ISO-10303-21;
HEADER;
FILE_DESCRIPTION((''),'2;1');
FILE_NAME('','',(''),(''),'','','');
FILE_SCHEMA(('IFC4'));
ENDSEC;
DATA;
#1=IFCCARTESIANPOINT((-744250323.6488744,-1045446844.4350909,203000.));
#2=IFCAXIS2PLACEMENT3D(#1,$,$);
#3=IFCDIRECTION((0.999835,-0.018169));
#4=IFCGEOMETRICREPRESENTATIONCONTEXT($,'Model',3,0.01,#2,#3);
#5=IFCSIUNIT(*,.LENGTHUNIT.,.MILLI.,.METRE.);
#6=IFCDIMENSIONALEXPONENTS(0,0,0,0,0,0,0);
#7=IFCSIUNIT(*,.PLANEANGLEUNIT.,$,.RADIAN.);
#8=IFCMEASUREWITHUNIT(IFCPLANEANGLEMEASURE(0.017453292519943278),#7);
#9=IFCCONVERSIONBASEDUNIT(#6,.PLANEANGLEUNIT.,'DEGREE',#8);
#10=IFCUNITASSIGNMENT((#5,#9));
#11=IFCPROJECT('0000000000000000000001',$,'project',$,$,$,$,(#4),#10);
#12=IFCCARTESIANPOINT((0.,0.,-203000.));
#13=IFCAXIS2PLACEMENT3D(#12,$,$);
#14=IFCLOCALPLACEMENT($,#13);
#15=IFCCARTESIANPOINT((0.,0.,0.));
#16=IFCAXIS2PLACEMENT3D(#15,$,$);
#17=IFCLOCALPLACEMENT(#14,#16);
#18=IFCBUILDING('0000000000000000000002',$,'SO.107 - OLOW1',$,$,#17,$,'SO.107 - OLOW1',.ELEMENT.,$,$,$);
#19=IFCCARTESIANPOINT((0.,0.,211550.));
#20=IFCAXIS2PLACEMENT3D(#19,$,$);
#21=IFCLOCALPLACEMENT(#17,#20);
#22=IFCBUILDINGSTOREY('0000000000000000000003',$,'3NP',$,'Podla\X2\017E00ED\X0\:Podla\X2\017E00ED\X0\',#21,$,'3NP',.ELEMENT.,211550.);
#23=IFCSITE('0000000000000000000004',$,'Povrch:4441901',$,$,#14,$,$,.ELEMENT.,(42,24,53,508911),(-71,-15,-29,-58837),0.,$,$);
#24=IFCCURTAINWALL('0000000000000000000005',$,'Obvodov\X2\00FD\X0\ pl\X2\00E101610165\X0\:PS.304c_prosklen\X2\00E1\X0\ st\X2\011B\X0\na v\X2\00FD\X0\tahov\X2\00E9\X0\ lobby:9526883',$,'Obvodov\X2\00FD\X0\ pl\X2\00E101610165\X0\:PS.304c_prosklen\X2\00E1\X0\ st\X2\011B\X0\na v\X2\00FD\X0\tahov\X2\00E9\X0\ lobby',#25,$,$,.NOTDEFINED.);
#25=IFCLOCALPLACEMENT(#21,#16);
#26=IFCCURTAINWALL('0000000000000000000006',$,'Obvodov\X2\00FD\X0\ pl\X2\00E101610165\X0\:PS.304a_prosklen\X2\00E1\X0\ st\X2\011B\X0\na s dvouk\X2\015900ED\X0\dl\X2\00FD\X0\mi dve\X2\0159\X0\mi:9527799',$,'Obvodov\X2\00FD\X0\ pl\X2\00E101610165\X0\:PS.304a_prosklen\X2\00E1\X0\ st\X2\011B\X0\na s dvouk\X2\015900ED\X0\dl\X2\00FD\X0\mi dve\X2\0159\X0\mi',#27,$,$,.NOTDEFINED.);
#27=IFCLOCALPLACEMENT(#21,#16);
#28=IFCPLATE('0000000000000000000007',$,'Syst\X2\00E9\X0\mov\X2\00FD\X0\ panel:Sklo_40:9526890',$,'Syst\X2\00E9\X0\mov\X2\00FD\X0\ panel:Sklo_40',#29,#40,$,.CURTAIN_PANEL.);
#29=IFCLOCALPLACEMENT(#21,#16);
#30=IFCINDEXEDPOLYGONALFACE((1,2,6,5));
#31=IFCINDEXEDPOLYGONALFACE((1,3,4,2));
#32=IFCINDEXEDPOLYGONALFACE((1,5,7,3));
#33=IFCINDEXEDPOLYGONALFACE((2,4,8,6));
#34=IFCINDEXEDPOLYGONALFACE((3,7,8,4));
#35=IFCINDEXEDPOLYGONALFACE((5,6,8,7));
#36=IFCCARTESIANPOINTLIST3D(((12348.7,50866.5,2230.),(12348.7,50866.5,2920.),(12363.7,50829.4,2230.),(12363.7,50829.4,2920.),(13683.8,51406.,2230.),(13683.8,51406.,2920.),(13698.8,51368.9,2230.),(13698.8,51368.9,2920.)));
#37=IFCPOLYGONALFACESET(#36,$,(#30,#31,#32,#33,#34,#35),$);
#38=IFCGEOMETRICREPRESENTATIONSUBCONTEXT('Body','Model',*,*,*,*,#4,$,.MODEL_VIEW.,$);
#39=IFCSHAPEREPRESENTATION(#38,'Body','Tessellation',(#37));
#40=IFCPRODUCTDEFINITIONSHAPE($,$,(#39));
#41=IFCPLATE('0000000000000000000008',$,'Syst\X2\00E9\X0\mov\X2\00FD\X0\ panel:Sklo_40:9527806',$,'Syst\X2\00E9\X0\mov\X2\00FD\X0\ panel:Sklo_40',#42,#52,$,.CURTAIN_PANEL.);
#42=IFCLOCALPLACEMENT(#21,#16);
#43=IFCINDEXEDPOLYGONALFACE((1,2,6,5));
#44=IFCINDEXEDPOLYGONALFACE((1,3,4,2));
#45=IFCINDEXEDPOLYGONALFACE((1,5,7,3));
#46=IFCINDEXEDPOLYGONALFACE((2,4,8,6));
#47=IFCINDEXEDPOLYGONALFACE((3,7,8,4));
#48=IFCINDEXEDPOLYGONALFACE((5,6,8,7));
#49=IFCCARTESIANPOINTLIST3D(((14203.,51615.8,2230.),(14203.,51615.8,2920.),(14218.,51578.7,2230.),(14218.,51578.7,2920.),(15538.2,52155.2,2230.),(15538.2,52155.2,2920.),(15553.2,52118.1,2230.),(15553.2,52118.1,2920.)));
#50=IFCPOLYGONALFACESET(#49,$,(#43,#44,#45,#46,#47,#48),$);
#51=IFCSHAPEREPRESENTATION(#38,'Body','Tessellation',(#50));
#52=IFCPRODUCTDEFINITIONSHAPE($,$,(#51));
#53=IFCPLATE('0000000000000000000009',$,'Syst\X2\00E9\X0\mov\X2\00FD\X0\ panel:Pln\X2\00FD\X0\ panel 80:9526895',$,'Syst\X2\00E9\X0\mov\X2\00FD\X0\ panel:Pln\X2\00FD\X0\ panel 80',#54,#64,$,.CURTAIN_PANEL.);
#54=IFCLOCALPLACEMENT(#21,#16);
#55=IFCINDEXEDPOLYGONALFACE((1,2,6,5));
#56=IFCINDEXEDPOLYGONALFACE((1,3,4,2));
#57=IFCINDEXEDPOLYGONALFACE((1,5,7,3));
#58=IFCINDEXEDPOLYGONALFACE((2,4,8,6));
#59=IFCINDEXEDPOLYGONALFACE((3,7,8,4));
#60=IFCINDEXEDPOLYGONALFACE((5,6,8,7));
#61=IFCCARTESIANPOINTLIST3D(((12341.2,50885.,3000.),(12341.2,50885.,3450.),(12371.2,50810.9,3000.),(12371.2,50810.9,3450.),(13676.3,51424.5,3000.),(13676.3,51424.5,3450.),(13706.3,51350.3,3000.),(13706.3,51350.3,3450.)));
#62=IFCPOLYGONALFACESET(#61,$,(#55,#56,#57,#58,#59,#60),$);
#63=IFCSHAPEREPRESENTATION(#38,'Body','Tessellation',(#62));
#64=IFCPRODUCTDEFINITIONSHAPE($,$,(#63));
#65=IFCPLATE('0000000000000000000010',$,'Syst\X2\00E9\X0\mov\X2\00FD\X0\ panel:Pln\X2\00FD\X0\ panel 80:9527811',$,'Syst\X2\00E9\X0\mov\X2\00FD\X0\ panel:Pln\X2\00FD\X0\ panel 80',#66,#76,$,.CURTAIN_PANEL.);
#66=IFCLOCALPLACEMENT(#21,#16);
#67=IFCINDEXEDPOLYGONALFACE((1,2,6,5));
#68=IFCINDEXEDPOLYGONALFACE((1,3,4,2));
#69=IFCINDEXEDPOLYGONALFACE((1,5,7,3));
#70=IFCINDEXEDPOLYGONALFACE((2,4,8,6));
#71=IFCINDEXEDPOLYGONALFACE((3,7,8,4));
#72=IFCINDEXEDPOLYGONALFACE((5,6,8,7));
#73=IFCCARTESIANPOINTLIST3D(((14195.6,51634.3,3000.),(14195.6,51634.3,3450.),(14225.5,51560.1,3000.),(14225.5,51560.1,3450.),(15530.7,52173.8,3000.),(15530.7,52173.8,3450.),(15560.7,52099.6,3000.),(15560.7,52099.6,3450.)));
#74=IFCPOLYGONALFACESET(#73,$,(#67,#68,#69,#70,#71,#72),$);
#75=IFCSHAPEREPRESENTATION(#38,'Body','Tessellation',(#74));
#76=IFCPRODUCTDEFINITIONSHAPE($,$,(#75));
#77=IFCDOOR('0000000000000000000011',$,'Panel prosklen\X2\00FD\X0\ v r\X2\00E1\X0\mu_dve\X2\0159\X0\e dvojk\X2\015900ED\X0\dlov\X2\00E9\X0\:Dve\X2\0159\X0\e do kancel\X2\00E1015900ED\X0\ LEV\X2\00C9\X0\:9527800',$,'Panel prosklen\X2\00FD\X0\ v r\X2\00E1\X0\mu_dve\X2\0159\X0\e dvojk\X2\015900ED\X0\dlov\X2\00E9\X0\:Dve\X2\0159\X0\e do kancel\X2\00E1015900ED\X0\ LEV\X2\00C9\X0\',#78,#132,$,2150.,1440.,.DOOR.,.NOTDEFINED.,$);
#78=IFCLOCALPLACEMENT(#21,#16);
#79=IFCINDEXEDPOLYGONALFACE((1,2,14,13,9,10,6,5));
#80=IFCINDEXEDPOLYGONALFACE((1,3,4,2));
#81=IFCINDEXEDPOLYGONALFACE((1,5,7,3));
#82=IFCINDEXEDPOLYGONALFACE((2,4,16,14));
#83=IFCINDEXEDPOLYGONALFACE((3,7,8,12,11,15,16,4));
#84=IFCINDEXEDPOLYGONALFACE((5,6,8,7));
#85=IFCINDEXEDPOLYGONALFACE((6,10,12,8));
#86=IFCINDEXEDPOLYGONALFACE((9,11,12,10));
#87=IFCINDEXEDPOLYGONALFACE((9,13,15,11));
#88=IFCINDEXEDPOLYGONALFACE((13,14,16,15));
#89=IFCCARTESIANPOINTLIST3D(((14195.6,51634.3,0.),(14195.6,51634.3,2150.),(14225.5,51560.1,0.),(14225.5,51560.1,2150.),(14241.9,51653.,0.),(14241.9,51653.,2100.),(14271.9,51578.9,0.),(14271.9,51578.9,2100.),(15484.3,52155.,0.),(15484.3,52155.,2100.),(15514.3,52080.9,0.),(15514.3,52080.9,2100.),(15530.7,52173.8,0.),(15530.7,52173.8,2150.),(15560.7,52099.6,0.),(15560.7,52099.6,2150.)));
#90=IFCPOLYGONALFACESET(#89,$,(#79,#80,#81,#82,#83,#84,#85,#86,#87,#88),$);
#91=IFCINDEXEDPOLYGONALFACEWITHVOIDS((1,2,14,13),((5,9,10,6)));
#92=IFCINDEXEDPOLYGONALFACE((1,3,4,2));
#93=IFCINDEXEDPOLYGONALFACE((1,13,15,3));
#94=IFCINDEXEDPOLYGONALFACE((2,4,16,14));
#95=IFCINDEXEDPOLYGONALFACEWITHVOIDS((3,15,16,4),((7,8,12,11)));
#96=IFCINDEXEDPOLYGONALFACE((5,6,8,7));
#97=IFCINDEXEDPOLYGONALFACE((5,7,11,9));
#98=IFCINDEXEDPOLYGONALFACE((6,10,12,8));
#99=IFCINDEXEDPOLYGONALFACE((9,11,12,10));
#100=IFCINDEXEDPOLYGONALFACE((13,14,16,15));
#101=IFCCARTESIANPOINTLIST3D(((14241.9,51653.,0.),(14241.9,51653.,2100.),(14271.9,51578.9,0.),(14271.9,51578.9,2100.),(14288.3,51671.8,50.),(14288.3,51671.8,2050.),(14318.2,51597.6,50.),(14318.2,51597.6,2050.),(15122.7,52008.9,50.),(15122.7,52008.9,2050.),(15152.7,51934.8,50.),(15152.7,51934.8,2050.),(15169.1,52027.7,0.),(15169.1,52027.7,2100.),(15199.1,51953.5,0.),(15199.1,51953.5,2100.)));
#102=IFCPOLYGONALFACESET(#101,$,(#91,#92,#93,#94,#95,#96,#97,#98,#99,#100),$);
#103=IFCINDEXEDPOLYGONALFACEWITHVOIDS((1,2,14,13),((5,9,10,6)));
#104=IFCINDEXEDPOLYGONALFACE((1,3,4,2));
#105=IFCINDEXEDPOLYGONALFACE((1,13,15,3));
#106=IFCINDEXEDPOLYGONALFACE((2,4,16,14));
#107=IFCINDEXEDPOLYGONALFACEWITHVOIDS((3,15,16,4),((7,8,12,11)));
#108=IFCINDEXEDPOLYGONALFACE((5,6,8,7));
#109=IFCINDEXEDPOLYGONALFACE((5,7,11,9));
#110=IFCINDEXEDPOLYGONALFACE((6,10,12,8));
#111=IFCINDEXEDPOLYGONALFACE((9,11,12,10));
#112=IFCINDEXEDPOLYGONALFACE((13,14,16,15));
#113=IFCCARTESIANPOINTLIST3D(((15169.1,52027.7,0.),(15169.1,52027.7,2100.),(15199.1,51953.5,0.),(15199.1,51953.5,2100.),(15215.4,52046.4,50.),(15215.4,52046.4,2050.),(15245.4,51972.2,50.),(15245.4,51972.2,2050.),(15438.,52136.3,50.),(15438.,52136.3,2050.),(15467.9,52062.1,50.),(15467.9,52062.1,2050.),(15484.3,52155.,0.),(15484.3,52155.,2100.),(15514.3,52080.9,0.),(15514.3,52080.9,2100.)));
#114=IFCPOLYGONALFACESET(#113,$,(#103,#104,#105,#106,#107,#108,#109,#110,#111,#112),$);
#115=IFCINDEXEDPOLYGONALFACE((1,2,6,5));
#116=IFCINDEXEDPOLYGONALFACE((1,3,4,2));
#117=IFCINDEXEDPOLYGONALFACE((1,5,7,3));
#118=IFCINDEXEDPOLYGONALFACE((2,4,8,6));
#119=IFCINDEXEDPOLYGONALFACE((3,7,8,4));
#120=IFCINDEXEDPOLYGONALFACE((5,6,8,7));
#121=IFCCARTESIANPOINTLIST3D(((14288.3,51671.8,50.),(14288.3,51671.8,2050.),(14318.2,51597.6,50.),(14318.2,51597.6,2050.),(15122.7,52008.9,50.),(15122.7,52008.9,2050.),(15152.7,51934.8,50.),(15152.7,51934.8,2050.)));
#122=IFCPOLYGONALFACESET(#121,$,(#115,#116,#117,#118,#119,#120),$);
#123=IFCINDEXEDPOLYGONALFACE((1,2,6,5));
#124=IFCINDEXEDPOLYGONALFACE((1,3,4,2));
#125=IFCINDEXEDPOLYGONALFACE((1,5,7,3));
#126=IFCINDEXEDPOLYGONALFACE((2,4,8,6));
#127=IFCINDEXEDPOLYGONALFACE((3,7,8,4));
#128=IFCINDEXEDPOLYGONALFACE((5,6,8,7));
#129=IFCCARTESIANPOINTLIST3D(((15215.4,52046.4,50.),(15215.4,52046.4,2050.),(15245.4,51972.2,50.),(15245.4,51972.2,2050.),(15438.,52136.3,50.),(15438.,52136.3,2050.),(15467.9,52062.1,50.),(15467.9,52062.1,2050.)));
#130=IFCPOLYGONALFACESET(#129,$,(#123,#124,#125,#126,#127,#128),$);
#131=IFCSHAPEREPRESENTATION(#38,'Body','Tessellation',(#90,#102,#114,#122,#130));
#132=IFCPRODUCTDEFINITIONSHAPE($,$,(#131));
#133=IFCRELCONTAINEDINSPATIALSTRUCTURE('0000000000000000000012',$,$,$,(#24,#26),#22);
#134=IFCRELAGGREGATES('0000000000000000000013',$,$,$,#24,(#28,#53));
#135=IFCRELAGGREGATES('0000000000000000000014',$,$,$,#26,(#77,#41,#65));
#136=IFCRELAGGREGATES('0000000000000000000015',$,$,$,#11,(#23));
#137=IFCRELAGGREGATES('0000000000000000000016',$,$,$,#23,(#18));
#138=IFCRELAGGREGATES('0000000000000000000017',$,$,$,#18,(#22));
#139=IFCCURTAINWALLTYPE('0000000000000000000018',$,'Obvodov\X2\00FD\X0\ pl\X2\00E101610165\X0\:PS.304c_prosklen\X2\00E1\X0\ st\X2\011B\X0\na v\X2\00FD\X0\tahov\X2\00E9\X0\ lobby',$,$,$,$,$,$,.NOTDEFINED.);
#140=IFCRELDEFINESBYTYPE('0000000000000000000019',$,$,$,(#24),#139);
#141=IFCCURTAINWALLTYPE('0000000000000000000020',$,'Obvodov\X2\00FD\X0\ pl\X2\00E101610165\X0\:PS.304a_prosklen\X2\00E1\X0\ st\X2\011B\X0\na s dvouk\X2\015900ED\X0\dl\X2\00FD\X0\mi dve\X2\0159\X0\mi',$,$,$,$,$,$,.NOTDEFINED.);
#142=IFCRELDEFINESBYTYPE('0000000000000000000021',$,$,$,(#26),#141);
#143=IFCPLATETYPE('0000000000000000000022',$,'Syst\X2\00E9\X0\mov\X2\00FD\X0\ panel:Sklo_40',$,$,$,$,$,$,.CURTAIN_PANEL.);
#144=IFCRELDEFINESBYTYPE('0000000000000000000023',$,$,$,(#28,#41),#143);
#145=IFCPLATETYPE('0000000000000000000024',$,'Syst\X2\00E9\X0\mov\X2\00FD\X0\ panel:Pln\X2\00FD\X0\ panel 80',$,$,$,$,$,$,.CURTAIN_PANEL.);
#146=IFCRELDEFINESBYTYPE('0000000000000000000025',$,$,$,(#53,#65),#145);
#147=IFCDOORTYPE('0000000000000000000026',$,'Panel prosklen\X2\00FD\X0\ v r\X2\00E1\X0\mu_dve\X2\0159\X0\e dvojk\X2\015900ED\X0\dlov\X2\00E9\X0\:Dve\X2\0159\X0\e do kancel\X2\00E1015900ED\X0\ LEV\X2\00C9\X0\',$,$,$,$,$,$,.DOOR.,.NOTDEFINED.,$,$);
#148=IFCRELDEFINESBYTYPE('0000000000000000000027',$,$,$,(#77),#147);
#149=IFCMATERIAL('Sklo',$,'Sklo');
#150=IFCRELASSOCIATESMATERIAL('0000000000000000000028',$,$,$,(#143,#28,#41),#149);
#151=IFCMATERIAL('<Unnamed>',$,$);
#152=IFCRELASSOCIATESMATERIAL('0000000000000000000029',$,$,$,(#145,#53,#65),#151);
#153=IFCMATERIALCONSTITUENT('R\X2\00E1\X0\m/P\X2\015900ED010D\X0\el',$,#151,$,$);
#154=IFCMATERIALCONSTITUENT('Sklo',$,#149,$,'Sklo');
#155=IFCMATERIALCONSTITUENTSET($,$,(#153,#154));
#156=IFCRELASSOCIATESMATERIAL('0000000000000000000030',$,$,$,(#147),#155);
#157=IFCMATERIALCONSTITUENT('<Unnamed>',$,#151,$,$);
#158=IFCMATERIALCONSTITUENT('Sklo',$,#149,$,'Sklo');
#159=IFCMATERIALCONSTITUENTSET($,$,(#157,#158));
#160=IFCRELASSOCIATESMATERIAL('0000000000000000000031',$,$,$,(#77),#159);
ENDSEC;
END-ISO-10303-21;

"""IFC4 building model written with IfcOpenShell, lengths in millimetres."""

from ifc_helpers import new_model, entity, si_unit, converted_unit, direction, frame, origin, place, context, subcontext, project, spatial, indexed_curve, outline, extrude, source, transform, mapped, material, constituent, constituent_set, type_object, type_shapes, element, aggregate, save


model = new_model("IFC4")

# Units and contexts
model_context = context("Model", 3, precision=0.01, world=frame((-744250323.6488744, -1045446844.4350909, 203000.0)), true_north=direction((0.999835, -0.018169)))
body_context = subcontext(model_context, "Body", "Model", "MODEL_VIEW")
ifc_project = project(units=[si_unit("LENGTHUNIT", "METRE", prefix="MILLI"), converted_unit("PLANEANGLEUNIT", "DEGREE", entity("IfcPlaneAngleMeasure", 0.017453292519943278), si_unit("PLANEANGLEUNIT", "RADIAN"), dimensions=[0, 0, 0, 0, 0, 0, 0])], contexts=[model_context])

# Site, building, storey
site_placement = place(None, frame((0.0, 0.0, -203000.0)))
site = spatial("IfcSite", under=ifc_project, at=site_placement, Name="Povrch:4441901", CompositionType="ELEMENT", RefLatitude=(42, 24, 53, 508911), RefLongitude=(-71, -15, -29, -58837), RefElevation=0.0)
building_placement = place(site_placement, origin())
building = spatial("IfcBuilding", under=site, at=building_placement, Name="SO.107 - OLOW1", LongName="SO.107 - OLOW1", CompositionType="ELEMENT")
storey_placement = place(building_placement, frame((0.0, 0.0, 211550.0)))
storey = spatial("IfcBuildingStorey", under=building, at=storey_placement, Name="3NP", ObjectType="Podlaží:Podlaží", LongName="3NP", CompositionType="ELEMENT", Elevation=211550.0)

# Curtain walls
curtain_wall_type_1 = type_object("IfcCurtainWallType", Name="Obvodový plášť:PS.304c_prosklená stěna výtahové lobby", PredefinedType="NOTDEFINED")
curtain_wall_1_placement = place(storey_placement, frame((0.0, 0.0, -211550.0)))
curtain_wall_1 = element("IfcCurtainWall", 1, at=curtain_wall_1_placement, inside=storey, type_object=curtain_wall_type_1, Name="Obvodový plášť:PS.304c_prosklená stěna výtahové lobby:9526883", ObjectType="Obvodový plášť:PS.304c_prosklená stěna výtahové lobby", PredefinedType="NOTDEFINED")
ifc_material_1 = material(Name="<Unnamed>")
curtain_wall_type_2 = type_object("IfcCurtainWallType", Name="Obvodový plášť:PS.304a_prosklená stěna s dvoukřídlými dveřmi", PredefinedType="NOTDEFINED")
curtain_wall_2_placement = place(storey_placement, frame((0.0, 0.0, -211550.0)))
curtain_wall_2 = element("IfcCurtainWall", 2, at=curtain_wall_2_placement, inside=storey, type_object=curtain_wall_type_2, Name="Obvodový plášť:PS.304a_prosklená stěna s dvoukřídlými dveřmi:9527799", ObjectType="Obvodový plášť:PS.304a_prosklená stěna s dvoukřídlými dveřmi", PredefinedType="NOTDEFINED")

# Plates
ifc_material_2 = material(Name="Sklo", Category="Sklo")
plate_type_1 = type_object("IfcPlateType", Name="Systémový panel:Sklo_40", PredefinedType="CURTAIN_PANEL", material=ifc_material_2)
shared_shape_1 = source(origin(), body_context, "Body", "SweptSolid", [
    extrude(outline(indexed_curve([(-20.0, -720.0), (20.0, -720.0), (20.0, 720.0), (-20.0, 720.0), (-20.0, -720.0)], self_intersect=False)), frame((0.0, 0.0, 0.0), z_axis=(0.0, 0.0, 1.0), x_axis=(0.0, 1.0, 0.0)), (0.0, 0.0, 1.0), 690.0),
])
type_shapes(plate_type_1, [shared_shape_1])
plate_1_placement = place(curtain_wall_1_placement, frame((13023.8, 51117.7, 213780.0), z_axis=(0.0, 0.0, 1.0), x_axis=(0.927176, 0.374626, 0.0)))
plate_1 = element("IfcPlate", 3, at=plate_1_placement, type_object=plate_type_1, material=ifc_material_2, Name="Systémový panel:Sklo_40:9526890", ObjectType="Systémový panel:Sklo_40", PredefinedType="CURTAIN_PANEL", context=body_context, shape_type="MappedRepresentation", body=[
    mapped(shared_shape_1, transform((0.0, 0.0, 0.0), scale=1.0)),
])
plate_2_placement = place(curtain_wall_2_placement, frame((14878.1, 51866.9, 213780.0), z_axis=(0.0, 0.0, 1.0), x_axis=(-0.927176, -0.374626, 0.0)))
plate_2 = element("IfcPlate", 4, at=plate_2_placement, type_object=plate_type_1, material=ifc_material_2, Name="Systémový panel:Sklo_40:9527806", ObjectType="Systémový panel:Sklo_40", PredefinedType="CURTAIN_PANEL", context=body_context, shape_type="MappedRepresentation", body=[
    mapped(shared_shape_1, transform((0.0, 0.0, 0.0), scale=1.0)),
])
plate_type_2 = type_object("IfcPlateType", Name="Systémový panel:Plný panel 80", PredefinedType="CURTAIN_PANEL", material=ifc_material_1)
shared_shape_2 = source(origin(), body_context, "Body", "SweptSolid", [
    extrude(outline(indexed_curve([(-40.0, -720.0), (40.0, -720.0), (40.0, 720.0), (-40.0, 720.0), (-40.0, -720.0)], self_intersect=False)), frame((0.0, 0.0, 0.0), z_axis=(0.0, 0.0, 1.0), x_axis=(0.0, 1.0, 0.0)), (0.0, 0.0, 1.0), 450.0),
])
type_shapes(plate_type_2, [shared_shape_2])
plate_3_placement = place(curtain_wall_1_placement, frame((13023.8, 51117.7, 214550.0), z_axis=(0.0, 0.0, 1.0), x_axis=(0.927176, 0.374626, 0.0)))
plate_3 = element("IfcPlate", 5, at=plate_3_placement, type_object=plate_type_2, material=ifc_material_1, Name="Systémový panel:Plný panel 80:9526895", ObjectType="Systémový panel:Plný panel 80", PredefinedType="CURTAIN_PANEL", context=body_context, shape_type="MappedRepresentation", body=[
    mapped(shared_shape_2, transform((0.0, 0.0, 0.0), scale=1.0)),
])
aggregate(curtain_wall_1, [plate_1, plate_3])
plate_4_placement = place(curtain_wall_2_placement, frame((14878.1, 51866.9, 214550.0), z_axis=(0.0, 0.0, 1.0), x_axis=(-0.927176, -0.374626, 0.0)))
plate_4 = element("IfcPlate", 6, at=plate_4_placement, type_object=plate_type_2, material=ifc_material_1, Name="Systémový panel:Plný panel 80:9527811", ObjectType="Systémový panel:Plný panel 80", PredefinedType="CURTAIN_PANEL", context=body_context, shape_type="MappedRepresentation", body=[
    mapped(shared_shape_2, transform((0.0, 0.0, 0.0), scale=1.0)),
])

# Door
ifc_constituent_1 = constituent(ifc_material_1, Name="<Unnamed>")
ifc_constituent_2 = constituent(ifc_material_2, Name="Sklo", Category="Sklo")
ifc_constituent_set_1 = constituent_set(constituents=[ifc_constituent_1, ifc_constituent_2])
ifc_constituent_3 = constituent(ifc_material_1, Name="Rám/Příčel")
ifc_constituent_4 = constituent(ifc_material_2, Name="Sklo", Category="Sklo")
ifc_constituent_set_2 = constituent_set(constituents=[ifc_constituent_3, ifc_constituent_4])
door_type = type_object("IfcDoorType", Name="Panel prosklený v rámu_dveře dvojkřídlové:Dveře do kanceláří LEVÉ", OperationType="NOTDEFINED", PredefinedType="DOOR", material=ifc_constituent_set_2)
shared_shape_3 = source(origin(), body_context, "Body", "SweptSolid", [
    extrude(outline(indexed_curve([(-720.0, -1087.5), (720.0, -1087.5), (720.0, 1062.5), (670.0, 1062.5), (670.0, -1037.5), (-670.0, -1037.5), (-670.0, 1062.5), (-720.0, 1062.5), (-720.0, -1087.5)], self_intersect=False)), frame((0.0, 40.0, 1062.5), z_axis=(0.0, -1.0, 0.0), x_axis=(-1.0, 0.0, 0.0)), (0.0, 0.0, 1.0), 80.0),
    extrude(outline(indexed_curve([(-1050.0, -500.0), (1050.0, -500.0), (1050.0, 500.0), (-1050.0, 500.0), (-1050.0, -500.0)], self_intersect=False), holes=[indexed_curve([(-1000.0, -450.0), (-1000.0, 450.0), (1000.0, 450.0), (1000.0, -450.0), (-1000.0, -450.0)], self_intersect=False)]), frame((-170.0, 40.0, 1050.0), z_axis=(0.0, -1.0, 0.0), x_axis=(0.0, 0.0, -1.0)), (0.0, 0.0, 1.0), 80.0),
    extrude(outline(indexed_curve([(-1050.0, -170.0), (1050.0, -170.0), (1050.0, 170.0), (-1050.0, 170.0), (-1050.0, -170.0)], self_intersect=False), holes=[indexed_curve([(-1000.0, -120.0), (-1000.0, 120.0), (1000.0, 120.0), (1000.0, -120.0), (-1000.0, -120.0)], self_intersect=False)]), frame((500.0, 40.0, 1050.0), z_axis=(0.0, -1.0, 0.0), x_axis=(0.0, 0.0, -1.0)), (0.0, 0.0, 1.0), 80.0),
    extrude(outline(indexed_curve([(-450.0, -40.0), (450.0, -40.0), (450.0, 40.0), (-450.0, 40.0), (-450.0, -40.0)], self_intersect=False)), frame((-170.0, 0.0, 50.0)), (0.0, 0.0, 1.0), 2000.0),
    extrude(outline(indexed_curve([(-120.0, -40.0), (120.0, -40.0), (120.0, 40.0), (-120.0, 40.0), (-120.0, -40.0)], self_intersect=False)), frame((500.0, 0.0, 50.0)), (0.0, 0.0, 1.0), 2000.0),
])
type_shapes(door_type, [shared_shape_3])
door_placement = place(curtain_wall_2_placement, frame((14878.1, 51866.9, 211550.0), z_axis=(0.0, 0.0, 1.0), x_axis=(0.927176, 0.374626, 0.0)))
door = element("IfcDoor", 7, at=door_placement, type_object=door_type, material=ifc_constituent_set_1, Name="Panel prosklený v rámu_dveře dvojkřídlové:Dveře do kanceláří LEVÉ:9527800", ObjectType="Panel prosklený v rámu_dveře dvojkřídlové:Dveře do kanceláří LEVÉ", OperationType="NOTDEFINED", OverallHeight=2150.0, OverallWidth=1440.0, PredefinedType="DOOR", context=body_context, shape_type="MappedRepresentation", body=[
    mapped(shared_shape_3, transform((0.0, 0.0, 0.0), scale=1.0)),
])
aggregate(curtain_wall_2, [door, plate_2, plate_4])

save(model, "model.ifc")
